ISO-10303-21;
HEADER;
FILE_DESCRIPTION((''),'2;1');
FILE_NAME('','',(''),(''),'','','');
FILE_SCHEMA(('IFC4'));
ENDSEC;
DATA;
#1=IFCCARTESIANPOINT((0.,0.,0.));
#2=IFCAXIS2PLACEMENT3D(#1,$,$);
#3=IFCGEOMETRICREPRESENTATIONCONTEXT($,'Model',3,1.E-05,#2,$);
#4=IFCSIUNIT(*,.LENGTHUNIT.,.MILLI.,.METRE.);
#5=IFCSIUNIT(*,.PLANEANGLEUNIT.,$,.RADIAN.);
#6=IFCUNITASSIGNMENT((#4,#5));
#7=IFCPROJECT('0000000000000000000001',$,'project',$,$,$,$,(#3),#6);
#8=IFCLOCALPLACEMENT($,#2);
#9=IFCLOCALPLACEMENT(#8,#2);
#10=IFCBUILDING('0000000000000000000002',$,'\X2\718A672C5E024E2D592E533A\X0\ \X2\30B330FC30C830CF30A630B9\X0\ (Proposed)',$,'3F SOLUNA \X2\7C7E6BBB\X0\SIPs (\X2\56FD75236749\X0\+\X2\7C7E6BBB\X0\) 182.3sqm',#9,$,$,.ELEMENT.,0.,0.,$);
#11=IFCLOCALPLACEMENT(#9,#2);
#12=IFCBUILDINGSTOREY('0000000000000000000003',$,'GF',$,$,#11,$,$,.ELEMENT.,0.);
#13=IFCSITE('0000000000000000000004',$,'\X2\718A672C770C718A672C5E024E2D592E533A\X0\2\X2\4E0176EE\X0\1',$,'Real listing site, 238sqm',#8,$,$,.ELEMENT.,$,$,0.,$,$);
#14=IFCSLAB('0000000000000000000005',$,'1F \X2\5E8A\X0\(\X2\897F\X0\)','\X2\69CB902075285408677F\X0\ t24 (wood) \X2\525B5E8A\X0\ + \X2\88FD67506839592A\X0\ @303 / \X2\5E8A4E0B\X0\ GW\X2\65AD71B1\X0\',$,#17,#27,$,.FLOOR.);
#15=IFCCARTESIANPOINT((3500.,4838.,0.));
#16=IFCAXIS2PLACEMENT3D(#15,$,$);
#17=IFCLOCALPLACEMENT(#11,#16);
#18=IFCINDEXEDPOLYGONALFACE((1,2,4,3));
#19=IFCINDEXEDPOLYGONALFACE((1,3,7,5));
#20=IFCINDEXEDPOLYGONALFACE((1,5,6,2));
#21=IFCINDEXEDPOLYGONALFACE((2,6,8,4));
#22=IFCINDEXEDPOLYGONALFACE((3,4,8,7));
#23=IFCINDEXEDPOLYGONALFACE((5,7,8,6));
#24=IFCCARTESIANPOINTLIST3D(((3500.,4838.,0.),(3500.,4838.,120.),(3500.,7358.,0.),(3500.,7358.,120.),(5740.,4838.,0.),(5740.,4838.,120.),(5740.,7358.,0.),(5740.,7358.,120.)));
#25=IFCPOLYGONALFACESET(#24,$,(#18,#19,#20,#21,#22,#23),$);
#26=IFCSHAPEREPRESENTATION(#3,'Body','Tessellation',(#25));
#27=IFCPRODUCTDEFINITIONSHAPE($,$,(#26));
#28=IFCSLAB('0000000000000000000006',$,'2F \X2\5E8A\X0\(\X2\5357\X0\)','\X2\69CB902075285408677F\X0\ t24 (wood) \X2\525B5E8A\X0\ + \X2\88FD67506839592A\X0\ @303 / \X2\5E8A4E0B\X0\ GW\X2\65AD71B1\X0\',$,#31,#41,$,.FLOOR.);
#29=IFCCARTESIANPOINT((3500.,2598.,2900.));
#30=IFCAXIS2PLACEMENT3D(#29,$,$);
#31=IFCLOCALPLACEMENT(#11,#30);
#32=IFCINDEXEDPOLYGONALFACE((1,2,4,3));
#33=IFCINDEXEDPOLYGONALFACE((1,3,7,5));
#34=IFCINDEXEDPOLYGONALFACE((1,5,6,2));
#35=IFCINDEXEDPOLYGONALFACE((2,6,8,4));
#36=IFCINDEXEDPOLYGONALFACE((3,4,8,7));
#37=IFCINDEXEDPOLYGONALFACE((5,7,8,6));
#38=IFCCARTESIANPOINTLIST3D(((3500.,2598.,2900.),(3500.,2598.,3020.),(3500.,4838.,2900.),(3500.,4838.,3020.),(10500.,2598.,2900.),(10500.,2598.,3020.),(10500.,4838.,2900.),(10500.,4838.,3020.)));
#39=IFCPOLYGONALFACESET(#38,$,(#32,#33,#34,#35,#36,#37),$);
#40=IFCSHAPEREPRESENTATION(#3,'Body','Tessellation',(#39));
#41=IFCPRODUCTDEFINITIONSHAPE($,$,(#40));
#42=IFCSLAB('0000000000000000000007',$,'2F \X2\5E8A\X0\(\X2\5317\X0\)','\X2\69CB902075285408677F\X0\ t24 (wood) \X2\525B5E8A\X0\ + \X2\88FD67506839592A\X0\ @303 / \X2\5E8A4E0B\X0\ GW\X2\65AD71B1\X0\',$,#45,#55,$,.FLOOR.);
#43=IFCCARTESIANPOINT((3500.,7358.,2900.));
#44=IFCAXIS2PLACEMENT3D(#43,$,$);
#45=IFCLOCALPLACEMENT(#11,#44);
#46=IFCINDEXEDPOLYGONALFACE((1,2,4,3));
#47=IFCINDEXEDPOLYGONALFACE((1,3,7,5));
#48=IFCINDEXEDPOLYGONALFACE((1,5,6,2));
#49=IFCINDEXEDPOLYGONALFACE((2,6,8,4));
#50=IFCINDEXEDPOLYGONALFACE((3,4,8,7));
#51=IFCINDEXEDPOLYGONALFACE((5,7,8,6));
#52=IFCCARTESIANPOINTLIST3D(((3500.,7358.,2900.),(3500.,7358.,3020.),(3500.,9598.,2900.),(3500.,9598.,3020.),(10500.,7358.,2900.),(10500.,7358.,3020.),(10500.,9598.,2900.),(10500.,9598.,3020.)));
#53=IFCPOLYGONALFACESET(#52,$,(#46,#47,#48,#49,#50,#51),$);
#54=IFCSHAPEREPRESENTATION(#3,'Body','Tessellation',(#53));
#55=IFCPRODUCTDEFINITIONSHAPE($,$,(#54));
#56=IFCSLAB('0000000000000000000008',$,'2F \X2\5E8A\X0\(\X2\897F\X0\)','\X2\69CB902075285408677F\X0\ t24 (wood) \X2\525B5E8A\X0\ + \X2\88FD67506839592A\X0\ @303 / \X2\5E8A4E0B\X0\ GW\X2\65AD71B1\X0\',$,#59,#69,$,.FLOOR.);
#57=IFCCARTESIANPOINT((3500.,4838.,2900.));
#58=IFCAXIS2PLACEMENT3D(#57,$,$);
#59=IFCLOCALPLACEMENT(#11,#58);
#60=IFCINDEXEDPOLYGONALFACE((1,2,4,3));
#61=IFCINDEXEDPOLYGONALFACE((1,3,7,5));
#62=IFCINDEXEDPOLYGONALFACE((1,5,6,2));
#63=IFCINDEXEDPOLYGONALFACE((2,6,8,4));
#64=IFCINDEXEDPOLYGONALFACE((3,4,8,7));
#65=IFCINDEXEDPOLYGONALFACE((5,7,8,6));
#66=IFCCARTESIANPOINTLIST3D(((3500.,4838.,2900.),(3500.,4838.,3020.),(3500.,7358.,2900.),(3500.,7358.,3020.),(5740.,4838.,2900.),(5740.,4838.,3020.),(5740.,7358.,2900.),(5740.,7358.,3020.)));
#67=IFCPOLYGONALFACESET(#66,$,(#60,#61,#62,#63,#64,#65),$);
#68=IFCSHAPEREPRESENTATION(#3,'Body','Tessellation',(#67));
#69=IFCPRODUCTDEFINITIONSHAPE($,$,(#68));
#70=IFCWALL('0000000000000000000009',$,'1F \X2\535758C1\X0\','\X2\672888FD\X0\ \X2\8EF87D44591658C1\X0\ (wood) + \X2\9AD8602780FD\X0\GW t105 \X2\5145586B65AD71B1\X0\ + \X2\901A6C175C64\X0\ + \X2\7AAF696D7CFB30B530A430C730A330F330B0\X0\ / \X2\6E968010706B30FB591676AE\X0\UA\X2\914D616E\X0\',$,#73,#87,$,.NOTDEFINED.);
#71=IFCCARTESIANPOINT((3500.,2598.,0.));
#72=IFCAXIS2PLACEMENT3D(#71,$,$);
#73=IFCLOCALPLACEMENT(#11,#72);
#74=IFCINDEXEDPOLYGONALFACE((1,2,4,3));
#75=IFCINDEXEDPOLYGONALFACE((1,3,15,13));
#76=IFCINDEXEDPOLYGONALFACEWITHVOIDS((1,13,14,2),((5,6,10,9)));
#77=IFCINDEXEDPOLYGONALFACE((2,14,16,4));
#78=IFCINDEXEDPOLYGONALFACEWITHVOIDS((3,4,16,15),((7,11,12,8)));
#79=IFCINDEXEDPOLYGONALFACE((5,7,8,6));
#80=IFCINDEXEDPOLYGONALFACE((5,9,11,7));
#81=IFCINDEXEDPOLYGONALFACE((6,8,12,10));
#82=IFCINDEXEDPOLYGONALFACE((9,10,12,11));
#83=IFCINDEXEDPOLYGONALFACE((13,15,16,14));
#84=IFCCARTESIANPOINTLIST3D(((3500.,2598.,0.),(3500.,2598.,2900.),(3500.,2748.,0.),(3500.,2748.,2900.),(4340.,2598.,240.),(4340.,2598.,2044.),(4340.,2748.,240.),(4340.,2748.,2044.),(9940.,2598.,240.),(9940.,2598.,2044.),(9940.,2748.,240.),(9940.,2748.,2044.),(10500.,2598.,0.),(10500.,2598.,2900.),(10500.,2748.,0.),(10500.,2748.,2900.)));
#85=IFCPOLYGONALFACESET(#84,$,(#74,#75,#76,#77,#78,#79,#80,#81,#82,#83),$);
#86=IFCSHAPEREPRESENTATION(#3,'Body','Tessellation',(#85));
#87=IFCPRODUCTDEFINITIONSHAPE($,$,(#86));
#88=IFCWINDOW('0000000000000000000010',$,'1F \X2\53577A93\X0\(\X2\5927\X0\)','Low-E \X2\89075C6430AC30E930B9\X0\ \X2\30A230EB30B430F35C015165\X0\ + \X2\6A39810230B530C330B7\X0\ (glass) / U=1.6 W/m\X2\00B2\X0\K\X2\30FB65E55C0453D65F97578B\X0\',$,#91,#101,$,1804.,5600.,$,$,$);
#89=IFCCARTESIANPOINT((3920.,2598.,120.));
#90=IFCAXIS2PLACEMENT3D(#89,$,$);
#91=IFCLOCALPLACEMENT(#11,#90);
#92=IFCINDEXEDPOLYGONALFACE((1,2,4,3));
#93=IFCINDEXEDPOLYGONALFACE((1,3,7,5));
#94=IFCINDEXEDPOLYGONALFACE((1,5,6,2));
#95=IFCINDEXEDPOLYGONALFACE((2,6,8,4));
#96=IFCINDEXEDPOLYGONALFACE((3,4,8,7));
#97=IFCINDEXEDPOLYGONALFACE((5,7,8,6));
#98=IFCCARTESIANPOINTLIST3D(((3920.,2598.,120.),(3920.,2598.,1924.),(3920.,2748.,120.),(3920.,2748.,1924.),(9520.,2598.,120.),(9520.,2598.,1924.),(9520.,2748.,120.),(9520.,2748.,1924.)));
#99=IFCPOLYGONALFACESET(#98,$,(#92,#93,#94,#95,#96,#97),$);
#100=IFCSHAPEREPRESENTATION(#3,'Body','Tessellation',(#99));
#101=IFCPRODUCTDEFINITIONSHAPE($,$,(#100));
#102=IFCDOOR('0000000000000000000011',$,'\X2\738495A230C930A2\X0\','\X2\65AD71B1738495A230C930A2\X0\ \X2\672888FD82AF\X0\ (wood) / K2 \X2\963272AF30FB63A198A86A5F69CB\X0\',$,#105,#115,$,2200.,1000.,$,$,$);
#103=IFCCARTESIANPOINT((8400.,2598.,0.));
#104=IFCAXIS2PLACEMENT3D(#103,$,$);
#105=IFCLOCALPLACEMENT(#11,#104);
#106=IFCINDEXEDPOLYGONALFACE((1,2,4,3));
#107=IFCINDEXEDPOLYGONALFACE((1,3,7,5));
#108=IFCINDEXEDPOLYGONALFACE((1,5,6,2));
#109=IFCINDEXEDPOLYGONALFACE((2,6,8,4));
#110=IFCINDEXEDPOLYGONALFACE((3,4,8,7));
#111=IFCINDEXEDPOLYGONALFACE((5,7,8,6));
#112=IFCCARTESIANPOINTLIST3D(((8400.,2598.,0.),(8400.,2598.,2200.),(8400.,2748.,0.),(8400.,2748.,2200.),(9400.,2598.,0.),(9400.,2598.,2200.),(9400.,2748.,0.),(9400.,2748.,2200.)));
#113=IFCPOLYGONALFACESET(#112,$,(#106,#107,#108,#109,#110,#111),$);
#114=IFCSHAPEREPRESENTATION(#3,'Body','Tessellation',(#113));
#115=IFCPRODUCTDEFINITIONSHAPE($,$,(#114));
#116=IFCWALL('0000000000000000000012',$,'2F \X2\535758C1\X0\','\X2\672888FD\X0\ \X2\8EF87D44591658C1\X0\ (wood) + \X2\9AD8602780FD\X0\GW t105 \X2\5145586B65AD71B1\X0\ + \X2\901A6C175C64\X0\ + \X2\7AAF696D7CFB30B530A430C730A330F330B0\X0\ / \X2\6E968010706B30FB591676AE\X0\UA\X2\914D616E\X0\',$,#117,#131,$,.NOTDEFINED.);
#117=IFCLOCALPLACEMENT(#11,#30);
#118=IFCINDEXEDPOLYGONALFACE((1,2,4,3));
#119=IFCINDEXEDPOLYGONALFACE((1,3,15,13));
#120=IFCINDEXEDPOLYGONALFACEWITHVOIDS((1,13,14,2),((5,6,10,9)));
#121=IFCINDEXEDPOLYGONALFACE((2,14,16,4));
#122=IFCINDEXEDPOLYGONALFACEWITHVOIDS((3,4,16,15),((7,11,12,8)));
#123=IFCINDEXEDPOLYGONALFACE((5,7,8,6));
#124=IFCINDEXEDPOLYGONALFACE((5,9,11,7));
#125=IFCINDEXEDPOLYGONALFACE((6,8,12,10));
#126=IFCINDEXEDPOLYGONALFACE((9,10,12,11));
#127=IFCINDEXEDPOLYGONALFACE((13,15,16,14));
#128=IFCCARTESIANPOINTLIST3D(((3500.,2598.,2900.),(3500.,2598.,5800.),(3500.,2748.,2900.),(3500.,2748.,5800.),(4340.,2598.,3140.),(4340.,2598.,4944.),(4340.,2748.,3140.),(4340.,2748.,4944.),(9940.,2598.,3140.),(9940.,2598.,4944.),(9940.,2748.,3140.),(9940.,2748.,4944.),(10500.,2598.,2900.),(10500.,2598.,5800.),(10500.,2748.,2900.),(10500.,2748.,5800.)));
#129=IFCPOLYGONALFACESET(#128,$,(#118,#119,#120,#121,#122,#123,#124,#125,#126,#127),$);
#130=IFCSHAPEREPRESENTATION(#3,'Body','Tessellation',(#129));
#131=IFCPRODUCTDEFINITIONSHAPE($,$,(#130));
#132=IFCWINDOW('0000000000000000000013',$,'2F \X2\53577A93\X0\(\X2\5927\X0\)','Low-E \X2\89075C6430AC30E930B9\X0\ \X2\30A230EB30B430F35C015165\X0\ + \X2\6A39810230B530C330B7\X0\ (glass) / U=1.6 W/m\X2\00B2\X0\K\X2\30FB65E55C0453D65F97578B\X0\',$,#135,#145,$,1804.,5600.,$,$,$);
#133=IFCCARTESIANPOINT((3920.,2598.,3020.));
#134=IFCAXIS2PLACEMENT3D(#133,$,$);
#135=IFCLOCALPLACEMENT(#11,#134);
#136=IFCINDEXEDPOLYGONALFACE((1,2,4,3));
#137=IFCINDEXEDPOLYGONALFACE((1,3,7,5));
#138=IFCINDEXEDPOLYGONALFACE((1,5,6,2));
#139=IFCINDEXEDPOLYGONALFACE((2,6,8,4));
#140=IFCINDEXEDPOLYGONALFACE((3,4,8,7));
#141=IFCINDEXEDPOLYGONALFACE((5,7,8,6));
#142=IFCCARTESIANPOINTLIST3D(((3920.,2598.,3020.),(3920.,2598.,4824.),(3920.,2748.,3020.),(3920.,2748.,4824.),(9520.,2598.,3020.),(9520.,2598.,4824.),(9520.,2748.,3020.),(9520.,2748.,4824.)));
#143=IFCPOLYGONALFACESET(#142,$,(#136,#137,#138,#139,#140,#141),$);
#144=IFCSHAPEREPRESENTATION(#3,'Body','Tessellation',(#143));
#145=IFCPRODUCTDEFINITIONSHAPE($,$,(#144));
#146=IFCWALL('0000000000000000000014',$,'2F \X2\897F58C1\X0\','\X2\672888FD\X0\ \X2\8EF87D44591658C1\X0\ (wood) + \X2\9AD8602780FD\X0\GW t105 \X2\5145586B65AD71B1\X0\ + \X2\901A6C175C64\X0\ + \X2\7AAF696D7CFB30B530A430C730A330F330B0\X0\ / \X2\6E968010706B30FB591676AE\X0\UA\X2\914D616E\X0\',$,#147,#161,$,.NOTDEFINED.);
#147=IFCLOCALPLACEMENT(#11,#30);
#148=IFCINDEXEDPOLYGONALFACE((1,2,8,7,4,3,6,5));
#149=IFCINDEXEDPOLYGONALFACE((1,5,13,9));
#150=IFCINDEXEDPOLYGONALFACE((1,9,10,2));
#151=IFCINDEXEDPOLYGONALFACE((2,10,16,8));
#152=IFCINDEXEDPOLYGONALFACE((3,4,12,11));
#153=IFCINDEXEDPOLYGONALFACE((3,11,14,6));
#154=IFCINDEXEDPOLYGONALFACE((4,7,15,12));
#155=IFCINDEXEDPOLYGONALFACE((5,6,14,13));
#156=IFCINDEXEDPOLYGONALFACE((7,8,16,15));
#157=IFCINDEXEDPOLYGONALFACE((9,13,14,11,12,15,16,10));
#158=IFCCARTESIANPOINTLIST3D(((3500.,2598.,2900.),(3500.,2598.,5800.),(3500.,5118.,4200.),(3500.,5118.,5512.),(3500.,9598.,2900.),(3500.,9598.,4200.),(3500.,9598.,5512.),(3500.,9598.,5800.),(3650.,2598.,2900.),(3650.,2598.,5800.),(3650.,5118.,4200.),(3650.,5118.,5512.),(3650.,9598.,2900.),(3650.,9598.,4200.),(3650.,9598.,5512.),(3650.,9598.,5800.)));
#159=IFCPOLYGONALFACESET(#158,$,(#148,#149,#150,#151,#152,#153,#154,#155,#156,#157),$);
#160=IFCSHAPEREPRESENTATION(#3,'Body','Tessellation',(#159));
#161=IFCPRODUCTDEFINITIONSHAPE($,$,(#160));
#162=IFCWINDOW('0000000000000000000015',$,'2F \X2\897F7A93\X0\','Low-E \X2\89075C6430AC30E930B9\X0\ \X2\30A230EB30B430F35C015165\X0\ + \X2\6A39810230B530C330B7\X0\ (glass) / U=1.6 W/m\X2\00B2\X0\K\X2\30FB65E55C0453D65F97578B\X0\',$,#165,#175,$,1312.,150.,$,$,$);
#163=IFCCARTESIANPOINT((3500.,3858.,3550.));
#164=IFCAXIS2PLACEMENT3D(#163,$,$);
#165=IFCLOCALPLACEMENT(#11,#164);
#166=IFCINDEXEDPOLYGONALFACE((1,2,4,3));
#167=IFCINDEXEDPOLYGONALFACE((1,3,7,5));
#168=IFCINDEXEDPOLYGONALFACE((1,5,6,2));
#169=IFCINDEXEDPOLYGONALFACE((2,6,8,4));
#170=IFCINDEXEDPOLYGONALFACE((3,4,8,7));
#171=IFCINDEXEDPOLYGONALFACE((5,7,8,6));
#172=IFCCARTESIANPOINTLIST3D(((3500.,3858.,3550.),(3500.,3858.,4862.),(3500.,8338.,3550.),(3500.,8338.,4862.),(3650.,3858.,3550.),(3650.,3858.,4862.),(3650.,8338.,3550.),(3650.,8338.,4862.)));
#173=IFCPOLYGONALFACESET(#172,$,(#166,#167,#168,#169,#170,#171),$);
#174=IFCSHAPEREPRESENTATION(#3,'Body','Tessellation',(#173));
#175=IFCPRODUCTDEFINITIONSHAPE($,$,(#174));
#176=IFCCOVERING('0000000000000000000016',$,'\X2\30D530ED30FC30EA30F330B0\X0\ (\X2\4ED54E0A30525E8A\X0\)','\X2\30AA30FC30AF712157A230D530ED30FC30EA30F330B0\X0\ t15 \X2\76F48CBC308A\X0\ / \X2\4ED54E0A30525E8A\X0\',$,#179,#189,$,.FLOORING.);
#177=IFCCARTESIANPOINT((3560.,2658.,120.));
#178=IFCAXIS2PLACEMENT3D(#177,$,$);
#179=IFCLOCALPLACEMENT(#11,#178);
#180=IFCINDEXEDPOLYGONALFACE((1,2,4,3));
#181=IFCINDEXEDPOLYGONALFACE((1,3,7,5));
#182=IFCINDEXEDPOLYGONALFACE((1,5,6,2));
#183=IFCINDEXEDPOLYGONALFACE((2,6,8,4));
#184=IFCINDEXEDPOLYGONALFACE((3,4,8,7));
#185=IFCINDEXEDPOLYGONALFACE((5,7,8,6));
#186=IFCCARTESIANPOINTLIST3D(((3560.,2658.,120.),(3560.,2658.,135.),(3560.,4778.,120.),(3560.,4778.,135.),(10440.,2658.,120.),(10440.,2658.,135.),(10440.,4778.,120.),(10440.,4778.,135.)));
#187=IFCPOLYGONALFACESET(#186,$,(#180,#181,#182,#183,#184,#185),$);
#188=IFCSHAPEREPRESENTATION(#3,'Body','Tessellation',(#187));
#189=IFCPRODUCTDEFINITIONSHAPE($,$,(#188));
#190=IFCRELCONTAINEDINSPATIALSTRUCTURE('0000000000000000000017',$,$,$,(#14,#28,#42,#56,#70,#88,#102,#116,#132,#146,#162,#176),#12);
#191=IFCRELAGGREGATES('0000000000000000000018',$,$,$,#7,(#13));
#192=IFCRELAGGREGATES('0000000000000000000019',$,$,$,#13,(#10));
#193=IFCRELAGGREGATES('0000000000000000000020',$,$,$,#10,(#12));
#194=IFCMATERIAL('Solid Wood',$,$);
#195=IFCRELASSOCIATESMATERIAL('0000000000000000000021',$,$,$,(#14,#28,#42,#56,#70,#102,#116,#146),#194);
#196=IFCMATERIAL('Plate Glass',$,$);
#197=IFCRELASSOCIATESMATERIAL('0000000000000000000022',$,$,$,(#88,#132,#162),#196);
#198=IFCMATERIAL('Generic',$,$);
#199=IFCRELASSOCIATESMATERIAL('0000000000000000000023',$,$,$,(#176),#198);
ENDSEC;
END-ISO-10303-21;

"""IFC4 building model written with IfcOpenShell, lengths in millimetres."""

from ifc_helpers import new_model, si_unit, frame, frame_2d, origin, place, context, project, spatial, rectangle, extrude, material, element, fill, save


model = new_model("IFC4")

# Units and contexts
model_context = context("Model", 3, precision=1e-05, world=origin())
ifc_project = project(units=[si_unit("LENGTHUNIT", "METRE", prefix="MILLI"), si_unit("PLANEANGLEUNIT", "RADIAN")], contexts=[model_context])

# Site, building, storey
site_placement = place(None, origin())
site = spatial("IfcSite", under=ifc_project, at=site_placement, Name="熊本県熊本市中央区2丁目1", ObjectType="Real listing site, 238sqm", CompositionType="ELEMENT", RefElevation=0.0)
building_placement = place(site_placement, origin())
building = spatial("IfcBuilding", under=site, at=building_placement, Name="熊本市中央区 コートハウス (Proposed)", ObjectType="3F SOLUNA 籾殻SIPs (国産杉+籾殻) 182.3sqm", CompositionType="ELEMENT", ElevationOfRefHeight=0.0, ElevationOfTerrain=0.0)
storey_placement = place(building_placement, origin())
storey = spatial("IfcBuildingStorey", under=building, at=storey_placement, Name="GF", CompositionType="ELEMENT", Elevation=0.0)

# Slabs
ifc_material_1 = material(Name="Solid Wood")
slab_1_placement = place(storey_placement, frame((3500.0, 4838.0, 0.0)))
element("IfcSlab", 1, at=slab_1_placement, inside=storey, material=ifc_material_1, Name="1F 床(西)", Description="構造用合板 t24 (wood) 剛床 + 製材根太 @303 / 床下 GW断熱", PredefinedType="FLOOR", context=model_context, shape_type="SweptSolid", body=[
    extrude(rectangle(XDim=2240.0, YDim=2520.0, at=frame_2d((1120.0, 1260.0))), frame((3500.0, 4838.0, 0.0)), (0.0, 0.0, 1.0), 120.0),
])
slab_2_placement = place(storey_placement, frame((3500.0, 2598.0, 2900.0)))
element("IfcSlab", 2, at=slab_2_placement, inside=storey, material=ifc_material_1, Name="2F 床(南)", Description="構造用合板 t24 (wood) 剛床 + 製材根太 @303 / 床下 GW断熱", PredefinedType="FLOOR", context=model_context, shape_type="SweptSolid", body=[
    extrude(rectangle(XDim=7000.0, YDim=2240.0, at=frame_2d((3500.0, 1120.0))), frame((3500.0, 2598.0, 2900.0)), (0.0, 0.0, 1.0), 120.0),
])
slab_3_placement = place(storey_placement, frame((3500.0, 7358.0, 2900.0)))
element("IfcSlab", 3, at=slab_3_placement, inside=storey, material=ifc_material_1, Name="2F 床(北)", Description="構造用合板 t24 (wood) 剛床 + 製材根太 @303 / 床下 GW断熱", PredefinedType="FLOOR", context=model_context, shape_type="SweptSolid", body=[
    extrude(rectangle(XDim=7000.0, YDim=2240.0, at=frame_2d((3500.0, 1120.0))), frame((3500.0, 7358.0, 2900.0)), (0.0, 0.0, 1.0), 120.0),
])
slab_4_placement = place(storey_placement, frame((3500.0, 4838.0, 2900.0)))
element("IfcSlab", 4, at=slab_4_placement, inside=storey, material=ifc_material_1, Name="2F 床(西)", Description="構造用合板 t24 (wood) 剛床 + 製材根太 @303 / 床下 GW断熱", PredefinedType="FLOOR", context=model_context, shape_type="SweptSolid", body=[
    extrude(rectangle(XDim=2240.0, YDim=2520.0, at=frame_2d((1120.0, 1260.0))), frame((3500.0, 4838.0, 2900.0)), (0.0, 0.0, 1.0), 120.0),
])

# Wall, openings, window, door
wall_1_placement = place(storey_placement, frame((3500.0, 2598.0, 0.0)))
wall_1 = element("IfcWall", 5, at=wall_1_placement, inside=storey, material=ifc_material_1, Name="1F 南壁", Description="木製 軸組外壁 (wood) + 高性能GW t105 充填断熱 + 通気層 + 窯業系サイディング / 準耐火・外皮UA配慮", PredefinedType="NOTDEFINED", context=model_context, shape_type="SweptSolid", body=[
    extrude(rectangle(XDim=7000.0, YDim=150.0, at=frame_2d((3500.0, 75.0))), frame((3500.0, 2598.0, 0.0)), (0.0, 0.0, 1.0), 2900.0),
])
opening_1_placement = place(storey_placement, frame((3920.0, 2598.0, 120.0)))
opening_1 = element("IfcOpeningElement", 6, at=opening_1_placement, cuts=wall_1, PredefinedType="NOTDEFINED", context=model_context, shape_type="SweptSolid", body=[
    extrude(rectangle(XDim=5600.0, YDim=150.0, at=frame_2d((2800.0, 75.0))), frame((3920.0, 2598.0, 120.0)), (0.0, 0.0, 1.0), 1804.0),
])
opening_2_placement = place(storey_placement, frame((8400.0, 2598.0, 0.0)))
opening_2 = element("IfcOpeningElement", 7, at=opening_2_placement, cuts=wall_1, PredefinedType="NOTDEFINED", context=model_context, shape_type="SweptSolid", body=[
    extrude(rectangle(XDim=1000.0, YDim=150.0, at=frame_2d((500.0, 75.0))), frame((8400.0, 2598.0, 0.0)), (0.0, 0.0, 1.0), 2200.0),
])
ifc_material_2 = material(Name="Plate Glass")
window_1_placement = place(storey_placement, frame((3920.0, 2598.0, 120.0)))
window_1 = element("IfcWindow", 8, at=window_1_placement, inside=storey, material=ifc_material_2, Name="1F 南窓(大)", Description="Low-E 複層ガラス アルゴン封入 + 樹脂サッシ (glass) / U=1.6 W/m²K・日射取得型", OverallHeight=1804.0, OverallWidth=5600.0, context=model_context, shape_type="SweptSolid", body=[
    extrude(rectangle(XDim=5600.0, YDim=150.0, at=frame_2d((2800.0, 75.0))), frame((3920.0, 2598.0, 120.0)), (0.0, 0.0, 1.0), 1804.0),
])
fill(opening_1, window_1)
door_placement = place(storey_placement, frame((8400.0, 2598.0, 0.0)))
door = element("IfcDoor", 9, at=door_placement, inside=storey, material=ifc_material_1, Name="玄関ドア", Description="断熱玄関ドア 木製芯 (wood) / K2 防犯・採風機構", OverallHeight=2200.0, OverallWidth=1000.0, context=model_context, shape_type="SweptSolid", body=[
    extrude(rectangle(XDim=1000.0, YDim=150.0, at=frame_2d((500.0, 75.0))), frame((8400.0, 2598.0, 0.0)), (0.0, 0.0, 1.0), 2200.0),
])
fill(opening_2, door)

# Wall, opening, window
wall_2_placement = place(storey_placement, frame((3500.0, 2598.0, 2900.0)))
wall_2 = element("IfcWall", 10, at=wall_2_placement, inside=storey, material=ifc_material_1, Name="2F 南壁", Description="木製 軸組外壁 (wood) + 高性能GW t105 充填断熱 + 通気層 + 窯業系サイディング / 準耐火・外皮UA配慮", PredefinedType="NOTDEFINED", context=model_context, shape_type="SweptSolid", body=[
    extrude(rectangle(XDim=7000.0, YDim=150.0, at=frame_2d((3500.0, 75.0))), frame((3500.0, 2598.0, 2900.0)), (0.0, 0.0, 1.0), 2900.0),
])
opening_3_placement = place(storey_placement, frame((3920.0, 2598.0, 3020.0)))
opening_3 = element("IfcOpeningElement", 11, at=opening_3_placement, cuts=wall_2, PredefinedType="NOTDEFINED", context=model_context, shape_type="SweptSolid", body=[
    extrude(rectangle(XDim=5600.0, YDim=150.0, at=frame_2d((2800.0, 75.0))), frame((3920.0, 2598.0, 3020.0)), (0.0, 0.0, 1.0), 1804.0),
])
window_2_placement = place(storey_placement, frame((3920.0, 2598.0, 3020.0)))
window_2 = element("IfcWindow", 12, at=window_2_placement, inside=storey, material=ifc_material_2, Name="2F 南窓(大)", Description="Low-E 複層ガラス アルゴン封入 + 樹脂サッシ (glass) / U=1.6 W/m²K・日射取得型", OverallHeight=1804.0, OverallWidth=5600.0, context=model_context, shape_type="SweptSolid", body=[
    extrude(rectangle(XDim=5600.0, YDim=150.0, at=frame_2d((2800.0, 75.0))), frame((3920.0, 2598.0, 3020.0)), (0.0, 0.0, 1.0), 1804.0),
])
fill(opening_3, window_2)

# Wall, opening, window
wall_3_placement = place(storey_placement, frame((3500.0, 2598.0, 2900.0)))
wall_3 = element("IfcWall", 13, at=wall_3_placement, inside=storey, material=ifc_material_1, Name="2F 西壁", Description="木製 軸組外壁 (wood) + 高性能GW t105 充填断熱 + 通気層 + 窯業系サイディング / 準耐火・外皮UA配慮", PredefinedType="NOTDEFINED", context=model_context, shape_type="SweptSolid", body=[
    extrude(rectangle(XDim=150.0, YDim=7000.0, at=frame_2d((75.0, 3500.0))), frame((3500.0, 2598.0, 2900.0)), (0.0, 0.0, 1.0), 2900.0),
])
opening_4_placement = place(storey_placement, frame((3500.0, 3858.0, 3550.0)))
opening_4 = element("IfcOpeningElement", 14, at=opening_4_placement, cuts=wall_3, PredefinedType="NOTDEFINED", context=model_context, shape_type="SweptSolid", body=[
    extrude(rectangle(XDim=150.0, YDim=4480.0, at=frame_2d((75.0, 2240.0))), frame((3500.0, 3858.0, 3550.0)), (0.0, 0.0, 1.0), 1312.0),
])
window_3_placement = place(storey_placement, frame((3500.0, 3858.0, 3550.0)))
window_3 = element("IfcWindow", 15, at=window_3_placement, inside=storey, material=ifc_material_2, Name="2F 西窓", Description="Low-E 複層ガラス アルゴン封入 + 樹脂サッシ (glass) / U=1.6 W/m²K・日射取得型", OverallHeight=1312.0, OverallWidth=150.0, context=model_context, shape_type="SweptSolid", body=[
    extrude(rectangle(XDim=150.0, YDim=4480.0, at=frame_2d((75.0, 2240.0))), frame((3500.0, 3858.0, 3550.0)), (0.0, 0.0, 1.0), 1312.0),
])
fill(opening_4, window_3)

# Covering
ifc_material_3 = material(Name="Generic")
covering_1_placement = place(storey_placement, frame((3560.0, 2658.0, 120.0)))
element("IfcCovering", 16, at=covering_1_placement, inside=storey, material=ifc_material_3, Name="フローリング (仕上げ床)", Description="オーク無垢フローリング t15 直貼り / 仕上げ床", PredefinedType="FLOORING", context=model_context, shape_type="SweptSolid", body=[
    extrude(rectangle(XDim=6880.0, YDim=2120.0, at=frame_2d((3440.0, 1060.0))), frame((3560.0, 2658.0, 120.0)), (0.0, 0.0, 1.0), 15.0),
])

save(model, "model.ifc")
